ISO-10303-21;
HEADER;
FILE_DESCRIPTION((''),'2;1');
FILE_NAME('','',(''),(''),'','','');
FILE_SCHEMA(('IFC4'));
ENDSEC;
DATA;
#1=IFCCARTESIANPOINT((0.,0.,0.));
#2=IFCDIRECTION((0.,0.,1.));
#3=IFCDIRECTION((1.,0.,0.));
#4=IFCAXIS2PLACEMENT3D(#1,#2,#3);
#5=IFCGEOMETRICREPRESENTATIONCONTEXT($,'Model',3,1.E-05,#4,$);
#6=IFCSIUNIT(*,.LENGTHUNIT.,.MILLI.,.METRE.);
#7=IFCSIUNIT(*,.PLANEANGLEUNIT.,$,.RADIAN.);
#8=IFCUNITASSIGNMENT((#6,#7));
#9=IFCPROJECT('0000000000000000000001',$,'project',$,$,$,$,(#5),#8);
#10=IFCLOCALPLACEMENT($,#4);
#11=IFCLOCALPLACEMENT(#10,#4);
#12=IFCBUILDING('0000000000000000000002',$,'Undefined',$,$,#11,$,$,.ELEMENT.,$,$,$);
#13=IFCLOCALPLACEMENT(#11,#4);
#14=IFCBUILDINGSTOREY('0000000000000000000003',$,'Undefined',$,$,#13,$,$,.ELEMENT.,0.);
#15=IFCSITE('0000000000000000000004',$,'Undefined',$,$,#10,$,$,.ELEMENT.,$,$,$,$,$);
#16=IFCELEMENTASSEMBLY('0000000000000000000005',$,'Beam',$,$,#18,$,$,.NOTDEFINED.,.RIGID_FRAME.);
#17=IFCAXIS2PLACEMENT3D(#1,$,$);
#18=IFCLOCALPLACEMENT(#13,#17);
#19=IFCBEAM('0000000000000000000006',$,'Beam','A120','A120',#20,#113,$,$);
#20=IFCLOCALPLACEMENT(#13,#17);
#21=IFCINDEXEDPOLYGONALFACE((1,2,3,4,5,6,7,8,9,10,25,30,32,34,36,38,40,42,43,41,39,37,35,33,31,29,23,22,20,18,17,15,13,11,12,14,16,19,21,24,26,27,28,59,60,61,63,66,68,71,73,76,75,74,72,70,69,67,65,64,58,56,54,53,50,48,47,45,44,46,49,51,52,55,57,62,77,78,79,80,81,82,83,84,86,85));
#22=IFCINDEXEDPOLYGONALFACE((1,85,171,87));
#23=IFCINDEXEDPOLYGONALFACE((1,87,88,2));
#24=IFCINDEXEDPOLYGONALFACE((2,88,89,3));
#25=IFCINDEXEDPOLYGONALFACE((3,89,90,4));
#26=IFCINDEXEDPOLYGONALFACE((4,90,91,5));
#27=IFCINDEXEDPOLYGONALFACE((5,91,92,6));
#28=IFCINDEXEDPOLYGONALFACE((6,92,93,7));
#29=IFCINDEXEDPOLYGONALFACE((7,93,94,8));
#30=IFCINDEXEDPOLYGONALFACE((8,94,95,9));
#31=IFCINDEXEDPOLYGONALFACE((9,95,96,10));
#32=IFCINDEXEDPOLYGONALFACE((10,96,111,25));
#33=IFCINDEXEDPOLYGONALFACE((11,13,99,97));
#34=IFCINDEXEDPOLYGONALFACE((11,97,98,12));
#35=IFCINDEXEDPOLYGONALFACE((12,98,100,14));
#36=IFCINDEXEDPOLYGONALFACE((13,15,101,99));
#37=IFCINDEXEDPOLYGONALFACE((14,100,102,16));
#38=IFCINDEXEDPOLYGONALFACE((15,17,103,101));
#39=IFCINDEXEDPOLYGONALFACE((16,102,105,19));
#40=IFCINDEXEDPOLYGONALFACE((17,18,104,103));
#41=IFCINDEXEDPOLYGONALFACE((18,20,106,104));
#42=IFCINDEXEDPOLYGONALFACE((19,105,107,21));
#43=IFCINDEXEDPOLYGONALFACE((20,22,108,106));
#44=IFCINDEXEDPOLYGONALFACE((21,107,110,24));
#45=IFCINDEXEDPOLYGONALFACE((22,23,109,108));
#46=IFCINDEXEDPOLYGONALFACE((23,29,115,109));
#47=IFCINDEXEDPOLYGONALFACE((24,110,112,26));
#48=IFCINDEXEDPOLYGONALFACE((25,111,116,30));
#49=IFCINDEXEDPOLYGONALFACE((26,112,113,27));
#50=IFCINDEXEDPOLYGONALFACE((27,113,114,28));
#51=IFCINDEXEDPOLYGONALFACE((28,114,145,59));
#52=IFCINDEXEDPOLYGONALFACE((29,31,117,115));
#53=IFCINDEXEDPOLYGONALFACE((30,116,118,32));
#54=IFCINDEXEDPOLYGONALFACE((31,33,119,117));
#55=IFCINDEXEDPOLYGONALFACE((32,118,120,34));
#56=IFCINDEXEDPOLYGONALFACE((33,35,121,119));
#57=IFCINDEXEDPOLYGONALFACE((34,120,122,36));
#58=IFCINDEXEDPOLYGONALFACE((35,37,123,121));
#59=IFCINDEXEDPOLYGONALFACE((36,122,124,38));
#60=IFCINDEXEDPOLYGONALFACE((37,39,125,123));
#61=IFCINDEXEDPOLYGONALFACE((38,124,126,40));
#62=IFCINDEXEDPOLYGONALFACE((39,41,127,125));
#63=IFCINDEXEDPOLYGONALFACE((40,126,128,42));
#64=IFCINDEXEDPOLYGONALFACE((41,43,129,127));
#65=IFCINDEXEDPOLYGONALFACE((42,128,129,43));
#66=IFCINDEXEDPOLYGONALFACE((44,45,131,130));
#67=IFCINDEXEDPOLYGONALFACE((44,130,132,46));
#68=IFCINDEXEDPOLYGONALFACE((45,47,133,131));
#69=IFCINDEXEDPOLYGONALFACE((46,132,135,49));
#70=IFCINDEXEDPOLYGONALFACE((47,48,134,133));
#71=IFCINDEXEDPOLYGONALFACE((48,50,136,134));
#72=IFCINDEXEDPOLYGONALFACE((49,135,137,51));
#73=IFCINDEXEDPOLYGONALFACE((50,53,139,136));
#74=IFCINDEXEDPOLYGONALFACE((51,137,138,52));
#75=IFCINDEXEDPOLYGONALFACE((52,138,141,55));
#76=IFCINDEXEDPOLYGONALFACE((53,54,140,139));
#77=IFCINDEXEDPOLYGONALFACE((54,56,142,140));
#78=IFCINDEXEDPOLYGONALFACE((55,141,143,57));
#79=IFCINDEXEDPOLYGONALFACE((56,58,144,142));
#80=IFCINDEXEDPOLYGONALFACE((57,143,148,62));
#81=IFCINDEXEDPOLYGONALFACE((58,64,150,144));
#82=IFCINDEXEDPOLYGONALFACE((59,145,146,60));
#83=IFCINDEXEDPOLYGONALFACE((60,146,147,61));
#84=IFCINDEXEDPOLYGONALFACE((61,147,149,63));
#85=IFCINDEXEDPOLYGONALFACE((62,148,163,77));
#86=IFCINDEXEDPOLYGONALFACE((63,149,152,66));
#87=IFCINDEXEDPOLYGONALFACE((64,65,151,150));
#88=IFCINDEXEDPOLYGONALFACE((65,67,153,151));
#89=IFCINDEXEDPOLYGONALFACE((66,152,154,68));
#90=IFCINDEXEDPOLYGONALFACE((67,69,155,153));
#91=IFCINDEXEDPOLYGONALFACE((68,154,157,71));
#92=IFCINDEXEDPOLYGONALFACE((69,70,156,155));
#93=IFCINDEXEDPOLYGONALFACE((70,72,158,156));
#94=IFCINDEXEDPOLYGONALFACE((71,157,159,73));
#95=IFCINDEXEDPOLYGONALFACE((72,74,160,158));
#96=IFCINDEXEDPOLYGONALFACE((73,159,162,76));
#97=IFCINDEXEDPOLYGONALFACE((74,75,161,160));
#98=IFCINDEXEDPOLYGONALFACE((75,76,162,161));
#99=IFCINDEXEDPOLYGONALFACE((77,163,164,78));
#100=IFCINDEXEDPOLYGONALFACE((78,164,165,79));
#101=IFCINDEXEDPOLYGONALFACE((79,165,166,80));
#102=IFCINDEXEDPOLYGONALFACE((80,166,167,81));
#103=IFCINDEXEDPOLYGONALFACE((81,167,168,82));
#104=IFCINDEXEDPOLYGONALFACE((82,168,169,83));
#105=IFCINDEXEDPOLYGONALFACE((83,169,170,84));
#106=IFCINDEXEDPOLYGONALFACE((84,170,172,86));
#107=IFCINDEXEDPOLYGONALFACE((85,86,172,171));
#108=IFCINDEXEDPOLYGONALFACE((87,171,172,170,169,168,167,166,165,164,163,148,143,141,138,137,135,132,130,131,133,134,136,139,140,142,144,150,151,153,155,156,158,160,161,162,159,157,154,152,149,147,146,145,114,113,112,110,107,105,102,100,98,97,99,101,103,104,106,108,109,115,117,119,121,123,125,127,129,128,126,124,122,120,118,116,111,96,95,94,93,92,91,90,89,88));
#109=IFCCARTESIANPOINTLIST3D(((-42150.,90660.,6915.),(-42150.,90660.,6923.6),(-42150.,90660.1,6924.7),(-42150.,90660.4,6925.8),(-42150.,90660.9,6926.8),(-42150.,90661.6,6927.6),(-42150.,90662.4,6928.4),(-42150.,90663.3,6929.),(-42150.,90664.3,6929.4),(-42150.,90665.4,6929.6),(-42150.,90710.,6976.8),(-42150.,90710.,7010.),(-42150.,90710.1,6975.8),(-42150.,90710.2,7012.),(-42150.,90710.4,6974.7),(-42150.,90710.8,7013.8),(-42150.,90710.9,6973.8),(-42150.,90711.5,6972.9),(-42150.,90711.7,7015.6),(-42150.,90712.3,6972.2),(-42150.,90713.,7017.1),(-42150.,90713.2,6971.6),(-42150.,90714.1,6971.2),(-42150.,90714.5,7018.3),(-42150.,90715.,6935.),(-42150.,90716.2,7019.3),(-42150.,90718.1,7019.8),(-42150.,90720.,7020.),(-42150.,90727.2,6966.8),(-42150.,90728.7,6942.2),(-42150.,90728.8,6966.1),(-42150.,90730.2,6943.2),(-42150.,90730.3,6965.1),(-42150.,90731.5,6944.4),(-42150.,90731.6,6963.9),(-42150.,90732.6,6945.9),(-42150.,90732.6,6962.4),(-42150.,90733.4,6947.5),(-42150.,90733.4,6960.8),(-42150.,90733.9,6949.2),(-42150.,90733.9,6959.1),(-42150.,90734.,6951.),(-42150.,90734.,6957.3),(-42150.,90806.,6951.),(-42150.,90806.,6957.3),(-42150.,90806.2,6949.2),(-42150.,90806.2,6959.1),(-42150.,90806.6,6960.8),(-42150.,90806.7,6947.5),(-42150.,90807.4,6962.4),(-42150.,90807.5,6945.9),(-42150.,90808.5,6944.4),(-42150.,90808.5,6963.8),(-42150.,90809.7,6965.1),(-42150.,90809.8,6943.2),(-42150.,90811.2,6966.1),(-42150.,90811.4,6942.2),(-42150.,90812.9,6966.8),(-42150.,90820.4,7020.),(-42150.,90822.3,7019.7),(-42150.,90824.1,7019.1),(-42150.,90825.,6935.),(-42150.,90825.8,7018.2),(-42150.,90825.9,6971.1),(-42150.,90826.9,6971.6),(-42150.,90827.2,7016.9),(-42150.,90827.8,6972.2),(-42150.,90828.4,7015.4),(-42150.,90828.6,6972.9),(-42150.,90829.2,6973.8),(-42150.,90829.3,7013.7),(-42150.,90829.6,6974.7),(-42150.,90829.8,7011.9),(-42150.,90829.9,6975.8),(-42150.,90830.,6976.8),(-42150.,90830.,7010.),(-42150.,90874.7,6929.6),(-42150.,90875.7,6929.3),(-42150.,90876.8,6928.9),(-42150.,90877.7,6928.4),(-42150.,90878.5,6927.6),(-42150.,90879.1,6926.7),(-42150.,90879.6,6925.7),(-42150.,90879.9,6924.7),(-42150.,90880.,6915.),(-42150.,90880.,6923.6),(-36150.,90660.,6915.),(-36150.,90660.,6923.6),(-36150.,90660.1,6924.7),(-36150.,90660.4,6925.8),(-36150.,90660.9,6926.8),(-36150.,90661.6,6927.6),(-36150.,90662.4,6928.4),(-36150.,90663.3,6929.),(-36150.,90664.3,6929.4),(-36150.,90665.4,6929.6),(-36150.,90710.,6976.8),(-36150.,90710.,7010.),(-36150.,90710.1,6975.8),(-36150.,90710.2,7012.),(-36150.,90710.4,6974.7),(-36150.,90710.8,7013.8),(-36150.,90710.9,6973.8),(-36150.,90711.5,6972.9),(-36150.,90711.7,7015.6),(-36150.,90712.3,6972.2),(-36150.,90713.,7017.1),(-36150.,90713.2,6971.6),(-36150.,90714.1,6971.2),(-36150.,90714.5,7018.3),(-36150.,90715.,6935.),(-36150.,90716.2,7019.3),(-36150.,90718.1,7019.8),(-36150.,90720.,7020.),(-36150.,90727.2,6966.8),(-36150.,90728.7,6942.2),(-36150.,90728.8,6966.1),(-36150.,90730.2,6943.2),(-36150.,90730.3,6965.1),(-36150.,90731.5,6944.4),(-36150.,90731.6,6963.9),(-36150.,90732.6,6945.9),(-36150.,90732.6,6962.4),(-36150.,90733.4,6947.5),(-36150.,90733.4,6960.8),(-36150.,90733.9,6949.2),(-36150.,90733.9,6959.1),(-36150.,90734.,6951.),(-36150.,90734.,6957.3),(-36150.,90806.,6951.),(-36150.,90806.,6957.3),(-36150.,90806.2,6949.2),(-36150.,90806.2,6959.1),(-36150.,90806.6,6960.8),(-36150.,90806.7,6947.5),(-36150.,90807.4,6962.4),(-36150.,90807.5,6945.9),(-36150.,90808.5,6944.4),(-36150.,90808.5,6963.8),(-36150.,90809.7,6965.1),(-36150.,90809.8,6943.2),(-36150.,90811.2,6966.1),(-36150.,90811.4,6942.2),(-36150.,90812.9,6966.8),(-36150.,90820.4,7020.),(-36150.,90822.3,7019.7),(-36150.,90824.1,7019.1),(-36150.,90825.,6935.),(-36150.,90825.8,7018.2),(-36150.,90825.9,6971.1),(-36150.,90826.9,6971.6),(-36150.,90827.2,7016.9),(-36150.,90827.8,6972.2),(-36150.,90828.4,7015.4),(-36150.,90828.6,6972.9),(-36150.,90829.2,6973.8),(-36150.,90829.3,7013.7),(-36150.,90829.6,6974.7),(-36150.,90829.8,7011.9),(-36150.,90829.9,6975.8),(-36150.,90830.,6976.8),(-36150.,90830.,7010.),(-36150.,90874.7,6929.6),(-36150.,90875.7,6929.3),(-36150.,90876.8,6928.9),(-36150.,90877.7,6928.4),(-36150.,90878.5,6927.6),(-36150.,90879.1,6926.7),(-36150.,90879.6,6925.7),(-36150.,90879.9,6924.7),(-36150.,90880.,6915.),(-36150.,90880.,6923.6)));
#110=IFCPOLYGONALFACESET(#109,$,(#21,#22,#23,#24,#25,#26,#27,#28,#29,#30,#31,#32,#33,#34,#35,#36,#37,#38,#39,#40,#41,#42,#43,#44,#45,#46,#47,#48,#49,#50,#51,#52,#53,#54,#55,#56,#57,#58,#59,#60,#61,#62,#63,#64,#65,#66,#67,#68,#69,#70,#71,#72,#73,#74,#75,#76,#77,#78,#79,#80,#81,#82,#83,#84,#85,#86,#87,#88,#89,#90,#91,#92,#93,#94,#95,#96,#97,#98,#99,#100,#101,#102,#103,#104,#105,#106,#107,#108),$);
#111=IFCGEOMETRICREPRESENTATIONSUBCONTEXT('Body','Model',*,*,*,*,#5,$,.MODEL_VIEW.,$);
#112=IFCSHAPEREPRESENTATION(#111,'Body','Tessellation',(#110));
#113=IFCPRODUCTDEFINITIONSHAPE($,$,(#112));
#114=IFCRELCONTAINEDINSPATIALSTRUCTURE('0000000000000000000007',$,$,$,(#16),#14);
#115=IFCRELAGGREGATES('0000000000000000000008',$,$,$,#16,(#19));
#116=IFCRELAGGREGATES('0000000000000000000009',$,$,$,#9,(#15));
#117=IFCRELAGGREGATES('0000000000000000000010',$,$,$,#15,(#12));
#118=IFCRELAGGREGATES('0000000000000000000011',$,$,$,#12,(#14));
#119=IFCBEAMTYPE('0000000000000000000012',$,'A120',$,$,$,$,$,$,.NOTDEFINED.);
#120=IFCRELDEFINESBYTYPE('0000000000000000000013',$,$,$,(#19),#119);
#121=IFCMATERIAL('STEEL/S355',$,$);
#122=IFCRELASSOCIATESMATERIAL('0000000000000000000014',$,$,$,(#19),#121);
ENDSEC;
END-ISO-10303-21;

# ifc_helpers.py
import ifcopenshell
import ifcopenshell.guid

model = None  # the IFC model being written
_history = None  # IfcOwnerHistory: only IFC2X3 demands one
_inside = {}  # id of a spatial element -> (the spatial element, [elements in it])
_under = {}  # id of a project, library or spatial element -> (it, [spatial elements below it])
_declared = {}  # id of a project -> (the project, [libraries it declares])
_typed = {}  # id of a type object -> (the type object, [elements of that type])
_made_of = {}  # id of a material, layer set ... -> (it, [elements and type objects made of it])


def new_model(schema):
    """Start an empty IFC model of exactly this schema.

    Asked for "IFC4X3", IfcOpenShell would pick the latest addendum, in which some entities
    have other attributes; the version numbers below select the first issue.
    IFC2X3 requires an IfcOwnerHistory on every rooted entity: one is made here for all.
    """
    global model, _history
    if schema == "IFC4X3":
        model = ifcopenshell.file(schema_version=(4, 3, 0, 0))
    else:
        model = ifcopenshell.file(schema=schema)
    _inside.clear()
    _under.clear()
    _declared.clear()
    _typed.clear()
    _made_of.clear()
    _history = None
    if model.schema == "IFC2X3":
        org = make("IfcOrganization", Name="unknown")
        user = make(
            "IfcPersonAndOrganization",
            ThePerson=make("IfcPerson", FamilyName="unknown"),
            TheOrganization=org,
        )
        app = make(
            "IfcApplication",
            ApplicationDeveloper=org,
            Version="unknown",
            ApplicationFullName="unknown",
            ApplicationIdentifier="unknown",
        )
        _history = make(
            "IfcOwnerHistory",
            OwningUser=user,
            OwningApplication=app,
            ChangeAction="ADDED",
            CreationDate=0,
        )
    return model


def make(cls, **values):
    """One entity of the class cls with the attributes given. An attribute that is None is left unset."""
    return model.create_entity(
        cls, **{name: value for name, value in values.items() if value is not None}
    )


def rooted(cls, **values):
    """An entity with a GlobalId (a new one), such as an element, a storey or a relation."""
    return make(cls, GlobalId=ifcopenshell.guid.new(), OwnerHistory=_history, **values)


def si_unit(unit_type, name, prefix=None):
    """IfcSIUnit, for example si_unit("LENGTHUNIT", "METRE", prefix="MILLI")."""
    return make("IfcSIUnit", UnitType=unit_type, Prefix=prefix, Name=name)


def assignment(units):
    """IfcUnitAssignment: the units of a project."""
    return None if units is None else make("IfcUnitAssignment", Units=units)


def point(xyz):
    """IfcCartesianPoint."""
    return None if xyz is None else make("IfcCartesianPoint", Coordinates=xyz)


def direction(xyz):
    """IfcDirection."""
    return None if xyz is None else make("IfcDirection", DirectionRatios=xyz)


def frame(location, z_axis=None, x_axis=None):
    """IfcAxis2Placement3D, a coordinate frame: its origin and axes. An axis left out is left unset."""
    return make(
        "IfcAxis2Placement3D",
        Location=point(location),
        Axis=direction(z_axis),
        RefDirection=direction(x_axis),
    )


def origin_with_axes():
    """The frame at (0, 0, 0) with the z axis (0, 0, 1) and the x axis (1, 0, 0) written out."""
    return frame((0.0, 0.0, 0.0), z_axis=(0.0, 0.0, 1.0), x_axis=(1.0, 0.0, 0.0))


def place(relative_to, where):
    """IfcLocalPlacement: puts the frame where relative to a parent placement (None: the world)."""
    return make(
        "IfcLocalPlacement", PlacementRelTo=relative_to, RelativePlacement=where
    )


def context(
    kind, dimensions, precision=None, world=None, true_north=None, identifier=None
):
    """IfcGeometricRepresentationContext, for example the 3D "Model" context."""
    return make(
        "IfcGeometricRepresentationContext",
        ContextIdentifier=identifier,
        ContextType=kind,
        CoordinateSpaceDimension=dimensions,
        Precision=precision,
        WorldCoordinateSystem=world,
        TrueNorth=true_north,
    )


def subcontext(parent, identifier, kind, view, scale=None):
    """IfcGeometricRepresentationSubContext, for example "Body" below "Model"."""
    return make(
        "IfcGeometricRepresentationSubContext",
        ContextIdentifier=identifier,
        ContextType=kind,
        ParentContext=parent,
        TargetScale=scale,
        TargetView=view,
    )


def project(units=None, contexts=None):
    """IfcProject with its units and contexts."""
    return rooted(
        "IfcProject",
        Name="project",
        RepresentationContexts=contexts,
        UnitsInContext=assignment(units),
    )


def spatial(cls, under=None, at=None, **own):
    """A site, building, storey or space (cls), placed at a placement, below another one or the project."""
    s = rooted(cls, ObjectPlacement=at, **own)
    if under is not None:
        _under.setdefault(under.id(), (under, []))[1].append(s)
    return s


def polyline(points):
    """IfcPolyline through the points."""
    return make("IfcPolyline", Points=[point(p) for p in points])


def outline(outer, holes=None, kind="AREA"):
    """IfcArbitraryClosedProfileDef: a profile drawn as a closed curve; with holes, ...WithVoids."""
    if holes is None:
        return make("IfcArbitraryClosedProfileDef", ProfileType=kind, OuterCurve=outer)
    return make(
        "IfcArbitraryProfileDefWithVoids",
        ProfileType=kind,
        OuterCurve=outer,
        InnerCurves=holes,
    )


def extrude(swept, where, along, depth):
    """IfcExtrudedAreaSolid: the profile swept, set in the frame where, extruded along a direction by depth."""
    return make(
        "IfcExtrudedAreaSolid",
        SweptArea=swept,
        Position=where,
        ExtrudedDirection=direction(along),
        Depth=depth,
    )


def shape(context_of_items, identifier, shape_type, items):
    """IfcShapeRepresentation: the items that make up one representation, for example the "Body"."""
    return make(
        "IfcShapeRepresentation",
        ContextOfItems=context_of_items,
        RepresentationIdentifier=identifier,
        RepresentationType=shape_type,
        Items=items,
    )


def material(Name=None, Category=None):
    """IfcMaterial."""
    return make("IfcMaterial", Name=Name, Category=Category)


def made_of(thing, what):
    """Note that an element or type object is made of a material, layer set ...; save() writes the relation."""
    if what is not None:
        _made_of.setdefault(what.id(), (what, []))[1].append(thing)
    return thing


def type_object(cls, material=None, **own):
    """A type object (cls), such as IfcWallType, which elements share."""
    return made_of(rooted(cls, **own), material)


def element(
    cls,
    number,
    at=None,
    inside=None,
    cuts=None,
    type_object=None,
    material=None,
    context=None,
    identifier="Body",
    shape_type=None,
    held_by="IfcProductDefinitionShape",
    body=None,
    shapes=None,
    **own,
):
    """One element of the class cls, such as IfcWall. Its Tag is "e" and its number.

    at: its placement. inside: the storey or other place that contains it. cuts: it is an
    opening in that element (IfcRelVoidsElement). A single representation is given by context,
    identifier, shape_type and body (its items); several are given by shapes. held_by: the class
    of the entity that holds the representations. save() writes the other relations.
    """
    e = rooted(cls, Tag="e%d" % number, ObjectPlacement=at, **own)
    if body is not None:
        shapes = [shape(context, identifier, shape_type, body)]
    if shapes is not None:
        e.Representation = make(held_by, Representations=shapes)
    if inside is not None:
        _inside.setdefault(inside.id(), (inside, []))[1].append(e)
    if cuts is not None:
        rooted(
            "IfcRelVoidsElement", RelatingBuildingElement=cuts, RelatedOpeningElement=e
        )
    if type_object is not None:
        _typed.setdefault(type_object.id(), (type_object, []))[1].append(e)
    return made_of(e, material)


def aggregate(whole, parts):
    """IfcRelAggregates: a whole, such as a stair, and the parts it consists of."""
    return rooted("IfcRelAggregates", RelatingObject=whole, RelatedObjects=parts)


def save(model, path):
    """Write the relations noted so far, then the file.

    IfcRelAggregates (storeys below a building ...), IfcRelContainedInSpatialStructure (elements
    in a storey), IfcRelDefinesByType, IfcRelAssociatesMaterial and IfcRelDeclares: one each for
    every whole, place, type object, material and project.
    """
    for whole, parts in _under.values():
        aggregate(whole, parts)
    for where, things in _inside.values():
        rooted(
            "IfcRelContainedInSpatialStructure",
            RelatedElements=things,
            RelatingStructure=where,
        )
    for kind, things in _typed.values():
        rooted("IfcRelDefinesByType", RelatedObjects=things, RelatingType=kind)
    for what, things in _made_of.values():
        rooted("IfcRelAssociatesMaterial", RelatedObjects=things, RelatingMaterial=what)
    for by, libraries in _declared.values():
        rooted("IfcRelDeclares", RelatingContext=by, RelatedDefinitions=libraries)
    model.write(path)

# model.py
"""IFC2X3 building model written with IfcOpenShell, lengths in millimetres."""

from ifc_helpers import new_model, si_unit, frame, origin_with_axes, place, context, subcontext, project, spatial, polyline, outline, extrude, material, type_object, element, aggregate, save


model = new_model("IFC2X3")

# Units and contexts
model_context = context("Model", 3, precision=1e-05, world=origin_with_axes())
body_context = subcontext(model_context, "Body", "Model", "MODEL_VIEW")
ifc_project = project(units=[si_unit("LENGTHUNIT", "METRE", prefix="MILLI"), si_unit("PLANEANGLEUNIT", "RADIAN")], contexts=[model_context])

# Site, building, storey
site_placement = place(None, origin_with_axes())
site = spatial("IfcSite", under=ifc_project, at=site_placement, Name="Undefined", CompositionType="ELEMENT")
building_placement = place(site_placement, origin_with_axes())
building = spatial("IfcBuilding", under=site, at=building_placement, Name="Undefined", CompositionType="ELEMENT")
storey_placement = place(building_placement, origin_with_axes())
storey = spatial("IfcBuildingStorey", under=building, at=storey_placement, Name="Undefined", CompositionType="ELEMENT", Elevation=0.0)

# Element assembly, beam
ifc_material_1 = material(Name="STEEL/S355")
beam_type_1 = type_object("IfcBeamType", Name="A120", PredefinedType="NOTDEFINED")
assembly_1_placement = place(storey_placement, origin_with_axes())
assembly_1 = element("IfcElementAssembly", 1, at=assembly_1_placement, inside=storey, Name="Beam", AssemblyPlace="NOTDEFINED", PredefinedType="RIGID_FRAME")
beam_1_placement = place(assembly_1_placement, frame((-42150.0, 90770.0, 6967.5), z_axis=(0.0, 0.000118, 1.0), x_axis=(1.0, 0.0, 0.0)))
beam_1 = element("IfcBeam", 2, at=beam_1_placement, type_object=beam_type_1, material=ifc_material_1, Name="Beam", Description="A120", ObjectType="A120", context=body_context, shape_type="SweptSolid", body=[
    extrude(outline(polyline([(-110.0, -52.5), (-110.0, -43.9), (-109.9, -42.8), (-109.6, -41.8), (-109.1, -40.8), (-108.5, -39.9), (-107.7, -39.1), (-106.7, -38.6), (-105.7, -38.2), (-104.7, -37.9), (-55.0, -32.5), (-41.3, -25.3), (-39.8, -24.3), (-38.5, -23.1), (-37.4, -21.6), (-36.6, -20.0), (-36.2, -18.3), (-36.0, -16.5), (-36.0, -10.2), (-36.1, -8.4), (-36.6, -6.7), (-37.4, -5.1), (-38.4, -3.7), (-39.7, -2.4), (-41.2, -1.4), (-42.8, -0.7), (-55.9, 3.6), (-56.9, 4.1), (-57.8, 4.7), (-58.5, 5.4), (-59.2, 6.3), (-59.6, 7.2), (-59.9, 8.3), (-60.0, 9.3), (-60.0, 42.5), (-59.8, 44.4), (-59.3, 46.2), (-58.4, 47.9), (-57.2, 49.4), (-55.7, 50.7), (-54.1, 51.6), (-52.3, 52.2), (-50.4, 52.5), (50.0, 52.5), (51.9, 52.3), (53.8, 51.7), (55.5, 50.8), (57.1, 49.6), (58.3, 48.1), (59.2, 46.3), (59.8, 44.4), (60.0, 42.5), (60.0, 9.3), (59.9, 8.3), (59.6, 7.2), (59.2, 6.3), (58.5, 5.4), (57.8, 4.7), (56.9, 4.1), (55.9, 3.6), (42.8, -0.7), (41.2, -1.4), (39.7, -2.4), (38.4, -3.7), (37.4, -5.1), (36.6, -6.7), (36.1, -8.4), (36.0, -10.2), (36.0, -16.5), (36.2, -18.3), (36.6, -20.0), (37.4, -21.6), (38.5, -23.1), (39.8, -24.3), (41.3, -25.3), (55.0, -32.5), (104.7, -37.9), (105.7, -38.2), (106.7, -38.6), (107.7, -39.1), (108.5, -39.9), (109.1, -40.8), (109.6, -41.8), (109.9, -42.8), (110.0, -43.9), (110.0, -52.5), (-110.0, -52.5)])), frame((6000.0, 0.0, 0.0), z_axis=(-1.0, 0.0, 0.0), x_axis=(0.0, -1.0, 0.0)), (0.0, 0.0, 1.0), 6000.0),
])
aggregate(assembly_1, [beam_1])

save(model, "model.ifc")
